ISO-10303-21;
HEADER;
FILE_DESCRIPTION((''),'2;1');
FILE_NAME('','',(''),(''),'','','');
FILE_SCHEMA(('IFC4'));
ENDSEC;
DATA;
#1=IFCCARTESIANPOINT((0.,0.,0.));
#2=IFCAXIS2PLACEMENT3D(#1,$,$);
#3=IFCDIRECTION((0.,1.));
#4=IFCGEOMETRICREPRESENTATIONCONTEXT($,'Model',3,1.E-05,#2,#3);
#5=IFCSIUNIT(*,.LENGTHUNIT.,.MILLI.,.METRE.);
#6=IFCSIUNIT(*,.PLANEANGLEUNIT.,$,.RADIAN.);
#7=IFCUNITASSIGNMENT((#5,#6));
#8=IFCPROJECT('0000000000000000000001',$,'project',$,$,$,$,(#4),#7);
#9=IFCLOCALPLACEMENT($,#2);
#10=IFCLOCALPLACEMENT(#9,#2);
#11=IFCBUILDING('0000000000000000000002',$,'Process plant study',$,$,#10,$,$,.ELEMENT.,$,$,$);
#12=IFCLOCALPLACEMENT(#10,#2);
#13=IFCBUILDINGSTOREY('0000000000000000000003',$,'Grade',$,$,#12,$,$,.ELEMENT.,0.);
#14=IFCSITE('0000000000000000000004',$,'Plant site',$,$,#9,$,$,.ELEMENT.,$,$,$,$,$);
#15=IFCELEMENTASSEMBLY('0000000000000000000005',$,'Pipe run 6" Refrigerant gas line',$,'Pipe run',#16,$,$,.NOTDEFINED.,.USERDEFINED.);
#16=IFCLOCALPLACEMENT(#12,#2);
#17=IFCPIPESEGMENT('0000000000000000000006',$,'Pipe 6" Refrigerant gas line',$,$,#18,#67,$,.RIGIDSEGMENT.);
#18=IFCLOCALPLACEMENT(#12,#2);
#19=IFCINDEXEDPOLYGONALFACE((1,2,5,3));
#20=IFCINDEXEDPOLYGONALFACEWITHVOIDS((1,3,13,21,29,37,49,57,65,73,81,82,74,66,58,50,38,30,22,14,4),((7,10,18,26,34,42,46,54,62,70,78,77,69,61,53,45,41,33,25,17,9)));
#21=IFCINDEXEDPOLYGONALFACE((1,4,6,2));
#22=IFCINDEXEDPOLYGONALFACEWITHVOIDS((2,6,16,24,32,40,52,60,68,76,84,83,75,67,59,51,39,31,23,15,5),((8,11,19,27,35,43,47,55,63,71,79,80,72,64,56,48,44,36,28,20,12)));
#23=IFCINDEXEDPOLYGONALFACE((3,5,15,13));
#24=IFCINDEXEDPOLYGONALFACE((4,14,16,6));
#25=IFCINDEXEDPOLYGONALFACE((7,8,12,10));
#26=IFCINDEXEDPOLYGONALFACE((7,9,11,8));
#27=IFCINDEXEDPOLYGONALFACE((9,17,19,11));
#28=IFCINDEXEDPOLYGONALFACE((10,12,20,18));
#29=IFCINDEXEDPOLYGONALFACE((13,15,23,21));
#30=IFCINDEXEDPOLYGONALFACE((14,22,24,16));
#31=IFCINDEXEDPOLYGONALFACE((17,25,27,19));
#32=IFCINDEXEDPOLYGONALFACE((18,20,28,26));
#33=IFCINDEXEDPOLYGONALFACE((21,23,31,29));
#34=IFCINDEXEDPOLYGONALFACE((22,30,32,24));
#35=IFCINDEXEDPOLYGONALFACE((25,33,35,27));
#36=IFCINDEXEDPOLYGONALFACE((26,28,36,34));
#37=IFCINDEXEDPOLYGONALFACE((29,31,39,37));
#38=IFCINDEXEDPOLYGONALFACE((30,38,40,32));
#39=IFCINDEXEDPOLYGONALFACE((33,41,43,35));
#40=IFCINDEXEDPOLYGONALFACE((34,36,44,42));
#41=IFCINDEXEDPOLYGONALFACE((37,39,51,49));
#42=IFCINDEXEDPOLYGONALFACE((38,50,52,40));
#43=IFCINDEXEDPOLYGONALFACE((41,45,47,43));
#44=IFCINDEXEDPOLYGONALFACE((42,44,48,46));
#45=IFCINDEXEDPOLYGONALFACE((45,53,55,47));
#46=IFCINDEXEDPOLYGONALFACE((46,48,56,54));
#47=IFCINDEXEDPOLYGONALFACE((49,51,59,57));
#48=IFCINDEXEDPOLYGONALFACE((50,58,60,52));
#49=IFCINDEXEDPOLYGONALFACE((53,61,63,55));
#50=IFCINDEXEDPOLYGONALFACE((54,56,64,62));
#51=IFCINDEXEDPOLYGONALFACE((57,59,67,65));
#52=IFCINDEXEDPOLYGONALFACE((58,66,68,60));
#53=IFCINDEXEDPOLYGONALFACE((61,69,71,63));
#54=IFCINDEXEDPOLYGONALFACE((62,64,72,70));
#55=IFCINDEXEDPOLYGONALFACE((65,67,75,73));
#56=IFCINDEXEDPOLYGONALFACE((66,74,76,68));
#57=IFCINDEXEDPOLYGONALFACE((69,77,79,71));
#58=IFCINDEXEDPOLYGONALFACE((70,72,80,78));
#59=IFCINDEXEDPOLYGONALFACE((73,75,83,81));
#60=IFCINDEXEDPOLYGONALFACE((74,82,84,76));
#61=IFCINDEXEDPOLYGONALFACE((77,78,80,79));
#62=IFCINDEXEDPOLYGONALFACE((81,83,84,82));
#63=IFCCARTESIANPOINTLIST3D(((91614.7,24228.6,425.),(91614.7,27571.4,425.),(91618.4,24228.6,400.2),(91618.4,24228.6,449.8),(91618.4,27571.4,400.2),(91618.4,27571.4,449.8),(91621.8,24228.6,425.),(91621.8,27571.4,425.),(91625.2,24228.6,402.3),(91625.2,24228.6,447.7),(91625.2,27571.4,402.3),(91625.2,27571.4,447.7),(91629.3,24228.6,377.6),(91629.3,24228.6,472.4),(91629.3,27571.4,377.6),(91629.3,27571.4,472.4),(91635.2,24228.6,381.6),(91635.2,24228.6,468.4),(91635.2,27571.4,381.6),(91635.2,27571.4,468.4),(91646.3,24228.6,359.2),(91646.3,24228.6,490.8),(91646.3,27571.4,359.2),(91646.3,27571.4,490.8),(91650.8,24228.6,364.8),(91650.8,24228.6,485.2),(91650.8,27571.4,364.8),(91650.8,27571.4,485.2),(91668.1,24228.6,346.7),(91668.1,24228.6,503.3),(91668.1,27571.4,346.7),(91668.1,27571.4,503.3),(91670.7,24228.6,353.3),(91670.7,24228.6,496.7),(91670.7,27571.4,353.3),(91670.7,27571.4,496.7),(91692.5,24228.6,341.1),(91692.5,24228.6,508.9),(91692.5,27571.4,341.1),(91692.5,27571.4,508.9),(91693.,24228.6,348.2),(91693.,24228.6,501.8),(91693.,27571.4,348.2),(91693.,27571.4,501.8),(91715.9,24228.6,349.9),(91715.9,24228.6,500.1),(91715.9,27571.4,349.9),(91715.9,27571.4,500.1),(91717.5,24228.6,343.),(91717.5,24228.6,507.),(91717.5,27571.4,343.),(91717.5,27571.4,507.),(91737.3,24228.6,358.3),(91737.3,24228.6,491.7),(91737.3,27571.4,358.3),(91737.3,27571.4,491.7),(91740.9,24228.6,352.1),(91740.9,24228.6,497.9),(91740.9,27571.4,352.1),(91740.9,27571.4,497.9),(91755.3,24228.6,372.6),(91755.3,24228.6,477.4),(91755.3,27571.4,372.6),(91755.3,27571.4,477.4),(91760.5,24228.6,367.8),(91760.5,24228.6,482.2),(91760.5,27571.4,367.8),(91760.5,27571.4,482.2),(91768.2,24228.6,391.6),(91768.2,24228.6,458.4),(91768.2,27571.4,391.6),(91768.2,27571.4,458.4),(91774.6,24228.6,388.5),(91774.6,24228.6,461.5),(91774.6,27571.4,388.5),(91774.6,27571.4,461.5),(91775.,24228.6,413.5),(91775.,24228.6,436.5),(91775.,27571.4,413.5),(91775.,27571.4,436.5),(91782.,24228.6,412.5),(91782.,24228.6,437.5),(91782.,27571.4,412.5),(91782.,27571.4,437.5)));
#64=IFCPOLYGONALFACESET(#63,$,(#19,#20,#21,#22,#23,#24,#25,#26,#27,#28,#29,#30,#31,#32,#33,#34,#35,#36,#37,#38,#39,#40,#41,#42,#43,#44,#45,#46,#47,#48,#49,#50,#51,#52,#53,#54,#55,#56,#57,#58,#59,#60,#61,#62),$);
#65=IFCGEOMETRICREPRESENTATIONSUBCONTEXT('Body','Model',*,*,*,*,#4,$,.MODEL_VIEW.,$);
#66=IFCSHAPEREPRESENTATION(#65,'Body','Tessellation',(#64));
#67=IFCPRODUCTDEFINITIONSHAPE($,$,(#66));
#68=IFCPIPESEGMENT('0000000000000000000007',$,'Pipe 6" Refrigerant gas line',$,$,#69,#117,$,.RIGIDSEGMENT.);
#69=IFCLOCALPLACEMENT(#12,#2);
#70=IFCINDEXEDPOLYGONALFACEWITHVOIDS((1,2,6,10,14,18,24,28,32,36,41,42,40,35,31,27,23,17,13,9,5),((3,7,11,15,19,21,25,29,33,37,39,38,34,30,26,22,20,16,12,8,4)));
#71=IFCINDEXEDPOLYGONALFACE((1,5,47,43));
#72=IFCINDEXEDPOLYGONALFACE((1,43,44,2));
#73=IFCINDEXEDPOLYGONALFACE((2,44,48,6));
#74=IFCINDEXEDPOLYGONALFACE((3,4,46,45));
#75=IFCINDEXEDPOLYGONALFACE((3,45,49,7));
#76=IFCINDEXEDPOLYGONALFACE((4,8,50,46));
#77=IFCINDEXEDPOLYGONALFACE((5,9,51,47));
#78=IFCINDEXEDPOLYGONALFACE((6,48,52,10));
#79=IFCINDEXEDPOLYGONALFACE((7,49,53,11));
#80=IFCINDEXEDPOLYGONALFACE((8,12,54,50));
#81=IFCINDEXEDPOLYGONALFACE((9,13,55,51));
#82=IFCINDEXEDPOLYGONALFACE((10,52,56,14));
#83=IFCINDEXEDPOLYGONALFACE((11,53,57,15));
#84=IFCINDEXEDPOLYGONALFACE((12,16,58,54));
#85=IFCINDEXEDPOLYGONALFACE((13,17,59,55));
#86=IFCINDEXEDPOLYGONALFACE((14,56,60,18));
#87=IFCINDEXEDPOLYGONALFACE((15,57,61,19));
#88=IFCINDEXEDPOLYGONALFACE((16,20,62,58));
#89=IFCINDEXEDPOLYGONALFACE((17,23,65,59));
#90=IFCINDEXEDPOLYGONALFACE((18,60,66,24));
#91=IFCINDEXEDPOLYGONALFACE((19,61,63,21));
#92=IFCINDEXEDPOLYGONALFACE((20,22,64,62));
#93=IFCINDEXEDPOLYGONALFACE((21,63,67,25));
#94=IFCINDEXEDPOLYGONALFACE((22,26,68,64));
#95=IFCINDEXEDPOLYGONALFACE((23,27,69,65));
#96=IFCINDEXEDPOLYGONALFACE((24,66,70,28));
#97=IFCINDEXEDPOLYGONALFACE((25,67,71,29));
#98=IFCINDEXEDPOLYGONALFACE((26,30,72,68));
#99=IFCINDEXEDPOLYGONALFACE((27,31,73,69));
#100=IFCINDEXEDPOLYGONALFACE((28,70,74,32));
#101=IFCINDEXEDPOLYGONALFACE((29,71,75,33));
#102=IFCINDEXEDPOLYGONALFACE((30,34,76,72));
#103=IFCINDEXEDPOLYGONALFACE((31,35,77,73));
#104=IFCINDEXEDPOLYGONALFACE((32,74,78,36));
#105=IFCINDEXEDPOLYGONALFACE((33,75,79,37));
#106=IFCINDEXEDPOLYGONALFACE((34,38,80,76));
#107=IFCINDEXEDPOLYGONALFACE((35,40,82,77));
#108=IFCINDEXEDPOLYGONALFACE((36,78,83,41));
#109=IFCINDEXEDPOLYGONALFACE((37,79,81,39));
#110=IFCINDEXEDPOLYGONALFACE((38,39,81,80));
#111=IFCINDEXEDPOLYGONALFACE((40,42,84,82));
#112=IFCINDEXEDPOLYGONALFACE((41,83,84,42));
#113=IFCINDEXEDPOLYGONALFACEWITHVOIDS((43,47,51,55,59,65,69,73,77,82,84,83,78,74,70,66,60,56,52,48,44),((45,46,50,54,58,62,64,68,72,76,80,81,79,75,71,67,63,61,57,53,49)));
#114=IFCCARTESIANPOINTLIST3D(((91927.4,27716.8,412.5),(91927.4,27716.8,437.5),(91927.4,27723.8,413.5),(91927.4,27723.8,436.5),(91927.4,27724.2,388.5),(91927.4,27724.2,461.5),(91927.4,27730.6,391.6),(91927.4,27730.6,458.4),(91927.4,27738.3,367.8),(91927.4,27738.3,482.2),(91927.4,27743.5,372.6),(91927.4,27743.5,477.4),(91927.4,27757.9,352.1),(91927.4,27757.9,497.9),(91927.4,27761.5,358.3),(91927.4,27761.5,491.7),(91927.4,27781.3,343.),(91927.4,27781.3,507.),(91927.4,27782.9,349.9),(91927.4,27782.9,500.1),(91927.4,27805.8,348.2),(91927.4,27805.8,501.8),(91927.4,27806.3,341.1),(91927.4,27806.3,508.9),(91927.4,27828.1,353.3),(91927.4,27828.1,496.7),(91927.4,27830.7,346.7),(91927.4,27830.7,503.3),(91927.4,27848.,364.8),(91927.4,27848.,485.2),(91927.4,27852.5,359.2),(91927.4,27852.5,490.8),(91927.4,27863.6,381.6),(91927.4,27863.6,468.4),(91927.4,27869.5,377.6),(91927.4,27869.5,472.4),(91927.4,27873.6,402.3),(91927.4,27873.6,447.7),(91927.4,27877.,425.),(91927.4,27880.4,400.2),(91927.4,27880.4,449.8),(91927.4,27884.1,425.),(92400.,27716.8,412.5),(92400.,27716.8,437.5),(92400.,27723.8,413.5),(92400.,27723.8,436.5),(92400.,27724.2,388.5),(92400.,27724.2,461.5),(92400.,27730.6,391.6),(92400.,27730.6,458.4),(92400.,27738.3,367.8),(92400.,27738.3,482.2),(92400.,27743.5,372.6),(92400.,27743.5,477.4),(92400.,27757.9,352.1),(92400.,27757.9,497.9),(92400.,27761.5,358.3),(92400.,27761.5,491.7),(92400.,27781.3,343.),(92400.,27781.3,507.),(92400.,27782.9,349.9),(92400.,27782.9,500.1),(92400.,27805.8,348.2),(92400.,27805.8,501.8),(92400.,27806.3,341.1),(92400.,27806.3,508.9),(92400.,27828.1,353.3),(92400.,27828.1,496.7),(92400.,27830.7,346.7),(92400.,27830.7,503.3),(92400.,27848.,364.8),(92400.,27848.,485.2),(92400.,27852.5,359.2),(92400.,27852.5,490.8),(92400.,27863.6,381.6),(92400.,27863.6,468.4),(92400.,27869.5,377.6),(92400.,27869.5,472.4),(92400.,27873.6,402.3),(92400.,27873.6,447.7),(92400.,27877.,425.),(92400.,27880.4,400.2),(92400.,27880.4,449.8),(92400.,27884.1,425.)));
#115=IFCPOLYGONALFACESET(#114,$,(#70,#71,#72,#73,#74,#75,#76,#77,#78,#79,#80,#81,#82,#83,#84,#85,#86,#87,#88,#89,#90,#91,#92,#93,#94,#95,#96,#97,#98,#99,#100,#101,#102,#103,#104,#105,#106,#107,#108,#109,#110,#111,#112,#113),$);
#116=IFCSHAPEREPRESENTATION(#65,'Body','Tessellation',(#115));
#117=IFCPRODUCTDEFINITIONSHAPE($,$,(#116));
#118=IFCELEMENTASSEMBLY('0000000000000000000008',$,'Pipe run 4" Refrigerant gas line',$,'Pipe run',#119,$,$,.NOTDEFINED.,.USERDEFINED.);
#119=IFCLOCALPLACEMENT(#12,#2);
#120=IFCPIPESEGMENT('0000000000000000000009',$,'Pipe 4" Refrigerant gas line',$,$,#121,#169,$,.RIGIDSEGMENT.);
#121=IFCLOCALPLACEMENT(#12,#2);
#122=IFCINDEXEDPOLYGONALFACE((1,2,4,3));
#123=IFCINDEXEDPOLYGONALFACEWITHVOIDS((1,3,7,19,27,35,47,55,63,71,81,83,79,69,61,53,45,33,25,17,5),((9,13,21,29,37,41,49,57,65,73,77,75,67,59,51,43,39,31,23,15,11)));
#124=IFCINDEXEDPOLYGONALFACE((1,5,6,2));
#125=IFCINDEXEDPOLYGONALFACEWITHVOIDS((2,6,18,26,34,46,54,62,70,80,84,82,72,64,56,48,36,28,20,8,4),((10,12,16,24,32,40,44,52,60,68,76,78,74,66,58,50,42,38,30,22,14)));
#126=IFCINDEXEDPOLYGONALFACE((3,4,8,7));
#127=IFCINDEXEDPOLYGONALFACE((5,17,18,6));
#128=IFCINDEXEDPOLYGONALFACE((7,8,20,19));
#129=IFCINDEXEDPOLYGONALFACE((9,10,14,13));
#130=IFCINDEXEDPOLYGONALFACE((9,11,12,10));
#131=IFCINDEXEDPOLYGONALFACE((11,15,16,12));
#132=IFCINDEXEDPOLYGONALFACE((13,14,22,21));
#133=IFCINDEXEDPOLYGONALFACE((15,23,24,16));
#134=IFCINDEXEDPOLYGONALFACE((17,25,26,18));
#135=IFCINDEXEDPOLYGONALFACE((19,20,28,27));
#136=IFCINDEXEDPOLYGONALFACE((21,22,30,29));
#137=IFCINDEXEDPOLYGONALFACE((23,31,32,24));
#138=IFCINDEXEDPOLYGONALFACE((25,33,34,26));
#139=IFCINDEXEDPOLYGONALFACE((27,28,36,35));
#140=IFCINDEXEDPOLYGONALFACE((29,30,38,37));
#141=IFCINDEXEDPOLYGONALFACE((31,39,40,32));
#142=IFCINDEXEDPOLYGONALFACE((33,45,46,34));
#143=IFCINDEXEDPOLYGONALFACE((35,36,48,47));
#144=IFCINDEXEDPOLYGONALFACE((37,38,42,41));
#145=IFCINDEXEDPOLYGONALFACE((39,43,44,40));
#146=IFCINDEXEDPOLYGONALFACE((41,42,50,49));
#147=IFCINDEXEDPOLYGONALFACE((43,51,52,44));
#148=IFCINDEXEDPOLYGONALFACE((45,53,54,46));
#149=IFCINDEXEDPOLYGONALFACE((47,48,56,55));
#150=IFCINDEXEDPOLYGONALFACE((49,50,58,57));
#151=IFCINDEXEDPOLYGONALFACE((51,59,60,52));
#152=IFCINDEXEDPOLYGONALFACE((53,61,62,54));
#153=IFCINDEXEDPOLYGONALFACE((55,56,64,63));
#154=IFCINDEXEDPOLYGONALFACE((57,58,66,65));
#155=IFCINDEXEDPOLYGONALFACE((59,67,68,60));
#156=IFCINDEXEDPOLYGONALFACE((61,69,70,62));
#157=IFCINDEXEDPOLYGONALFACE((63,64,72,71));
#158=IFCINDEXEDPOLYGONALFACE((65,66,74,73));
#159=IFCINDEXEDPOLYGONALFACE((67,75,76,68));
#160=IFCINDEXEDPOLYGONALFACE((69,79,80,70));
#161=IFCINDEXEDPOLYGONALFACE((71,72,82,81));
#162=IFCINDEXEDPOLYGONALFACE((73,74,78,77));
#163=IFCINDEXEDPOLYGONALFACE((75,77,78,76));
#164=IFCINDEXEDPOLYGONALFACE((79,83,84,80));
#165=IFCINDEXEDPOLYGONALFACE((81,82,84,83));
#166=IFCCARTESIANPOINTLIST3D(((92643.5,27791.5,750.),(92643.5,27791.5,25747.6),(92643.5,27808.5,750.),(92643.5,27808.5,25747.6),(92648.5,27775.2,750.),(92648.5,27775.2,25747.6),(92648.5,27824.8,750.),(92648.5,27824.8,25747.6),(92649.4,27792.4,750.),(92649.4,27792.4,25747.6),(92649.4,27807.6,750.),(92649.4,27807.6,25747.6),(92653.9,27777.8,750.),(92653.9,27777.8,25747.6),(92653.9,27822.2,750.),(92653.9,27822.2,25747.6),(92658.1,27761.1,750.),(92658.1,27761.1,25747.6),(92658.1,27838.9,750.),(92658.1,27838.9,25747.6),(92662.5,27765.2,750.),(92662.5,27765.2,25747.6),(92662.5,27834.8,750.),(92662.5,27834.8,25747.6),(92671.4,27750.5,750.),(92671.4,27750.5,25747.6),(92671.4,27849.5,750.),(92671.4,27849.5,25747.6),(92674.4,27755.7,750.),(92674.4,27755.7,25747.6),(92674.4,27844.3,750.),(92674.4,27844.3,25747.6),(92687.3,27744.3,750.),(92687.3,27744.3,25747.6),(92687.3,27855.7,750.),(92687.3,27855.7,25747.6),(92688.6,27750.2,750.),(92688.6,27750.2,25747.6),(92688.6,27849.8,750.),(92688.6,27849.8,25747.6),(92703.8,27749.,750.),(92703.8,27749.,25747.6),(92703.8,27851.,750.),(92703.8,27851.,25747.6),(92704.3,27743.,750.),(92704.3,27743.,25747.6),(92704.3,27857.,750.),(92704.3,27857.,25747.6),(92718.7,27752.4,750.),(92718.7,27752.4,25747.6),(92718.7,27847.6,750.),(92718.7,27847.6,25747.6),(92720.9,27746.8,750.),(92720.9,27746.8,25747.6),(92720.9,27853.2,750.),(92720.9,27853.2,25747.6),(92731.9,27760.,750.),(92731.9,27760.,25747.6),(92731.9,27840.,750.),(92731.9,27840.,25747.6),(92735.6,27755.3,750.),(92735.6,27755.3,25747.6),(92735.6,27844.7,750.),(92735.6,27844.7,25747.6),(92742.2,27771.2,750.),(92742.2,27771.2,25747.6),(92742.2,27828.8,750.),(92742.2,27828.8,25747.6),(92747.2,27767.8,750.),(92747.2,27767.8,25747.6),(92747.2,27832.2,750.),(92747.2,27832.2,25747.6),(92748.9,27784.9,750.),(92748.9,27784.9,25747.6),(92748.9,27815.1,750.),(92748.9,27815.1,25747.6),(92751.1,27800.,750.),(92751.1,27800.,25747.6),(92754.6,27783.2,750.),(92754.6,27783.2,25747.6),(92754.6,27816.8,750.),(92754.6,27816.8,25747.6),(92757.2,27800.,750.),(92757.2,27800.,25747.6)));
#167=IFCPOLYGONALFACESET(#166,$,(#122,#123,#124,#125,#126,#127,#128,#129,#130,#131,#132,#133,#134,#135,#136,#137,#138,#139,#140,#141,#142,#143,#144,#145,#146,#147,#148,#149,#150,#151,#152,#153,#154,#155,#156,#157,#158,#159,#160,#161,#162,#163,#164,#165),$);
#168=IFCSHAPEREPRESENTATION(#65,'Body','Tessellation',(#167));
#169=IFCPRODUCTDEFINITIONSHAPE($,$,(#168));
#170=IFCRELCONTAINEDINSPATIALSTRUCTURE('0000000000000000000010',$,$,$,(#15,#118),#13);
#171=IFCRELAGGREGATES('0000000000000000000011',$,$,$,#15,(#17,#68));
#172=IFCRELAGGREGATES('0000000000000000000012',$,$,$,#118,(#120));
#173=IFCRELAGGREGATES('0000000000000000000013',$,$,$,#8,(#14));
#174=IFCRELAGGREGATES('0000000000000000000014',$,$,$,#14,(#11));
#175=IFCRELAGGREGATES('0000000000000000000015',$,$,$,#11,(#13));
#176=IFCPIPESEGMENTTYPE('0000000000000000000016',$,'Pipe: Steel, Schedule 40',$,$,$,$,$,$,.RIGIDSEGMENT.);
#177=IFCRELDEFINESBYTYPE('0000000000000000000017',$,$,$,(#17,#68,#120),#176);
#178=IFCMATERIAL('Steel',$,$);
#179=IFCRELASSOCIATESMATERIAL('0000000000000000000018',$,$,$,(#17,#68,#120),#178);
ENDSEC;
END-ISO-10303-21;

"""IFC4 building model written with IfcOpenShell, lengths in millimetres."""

from ifc_helpers import new_model, si_unit, direction, frame, origin, origin_with_axes, origin_2d, place, context, subcontext, project, spatial, hollow_circle, extrude, material, type_object, element, aggregate, save


model = new_model("IFC4")

# Units and contexts
model_context = context("Model", 3, precision=1e-05, world=origin(), true_north=direction((0.0, 1.0)))
body_context = subcontext(model_context, "Body", "Model", "MODEL_VIEW")
ifc_project = project(units=[si_unit("LENGTHUNIT", "METRE", prefix="MILLI"), si_unit("PLANEANGLEUNIT", "RADIAN")], contexts=[model_context])

# Site, building, storey
site_placement = place(None, origin())
site = spatial("IfcSite", under=ifc_project, at=site_placement, Name="Plant site", CompositionType="ELEMENT")
building_placement = place(site_placement, origin())
building = spatial("IfcBuilding", under=site, at=building_placement, Name="Process plant study", CompositionType="ELEMENT")
storey_placement = place(building_placement, origin())
storey = spatial("IfcBuildingStorey", under=building, at=storey_placement, Name="Grade", CompositionType="ELEMENT", Elevation=0.0)

# Element assemblies, pipe segments
ifc_material = material(Name="Steel")
pipe_segment_type = type_object("IfcPipeSegmentType", Name="Pipe: Steel, Schedule 40", PredefinedType="RIGIDSEGMENT")
assembly_1_placement = place(storey_placement, origin_with_axes())
assembly_1 = element("IfcElementAssembly", 1, at=assembly_1_placement, inside=storey, Name="Pipe run 6\" Refrigerant gas line", ObjectType="Pipe run", AssemblyPlace="NOTDEFINED", PredefinedType="USERDEFINED")
pipe_segment_1_placement = place(storey_placement, origin_with_axes())
pipe_segment_1 = element("IfcPipeSegment", 2, at=pipe_segment_1_placement, type_object=pipe_segment_type, material=ifc_material, Name="Pipe 6\" Refrigerant gas line", PredefinedType="RIGIDSEGMENT", context=body_context, shape_type="SweptSolid", body=[
    extrude(hollow_circle(Radius=84.1, WallThickness=7.1, at=origin_2d()), frame((91698.8, 24228.6, 425.0), z_axis=(0.0, 1.0, 0.0), x_axis=(-1.0, 0.0, 0.0)), (0.0, 0.0, 1.0), 3342.8),
])
pipe_segment_2_placement = place(storey_placement, origin_with_axes())
pipe_segment_2 = element("IfcPipeSegment", 3, at=pipe_segment_2_placement, type_object=pipe_segment_type, material=ifc_material, Name="Pipe 6\" Refrigerant gas line", PredefinedType="RIGIDSEGMENT", context=body_context, shape_type="SweptSolid", body=[
    extrude(hollow_circle(Radius=84.1, WallThickness=7.1, at=origin_2d()), frame((91927.4, 27800.0, 425.0), z_axis=(1.0, 0.0, 0.0), x_axis=(0.0, 1.0, 0.0)), (0.0, 0.0, 1.0), 472.6),
])
assembly_2_placement = place(storey_placement, origin_with_axes())
assembly_2 = element("IfcElementAssembly", 4, at=assembly_2_placement, inside=storey, Name="Pipe run 4\" Refrigerant gas line", ObjectType="Pipe run", AssemblyPlace="NOTDEFINED", PredefinedType="USERDEFINED")
pipe_segment_3_placement = place(storey_placement, origin_with_axes())
pipe_segment_3 = element("IfcPipeSegment", 5, at=pipe_segment_3_placement, type_object=pipe_segment_type, material=ifc_material, Name="Pipe 4\" Refrigerant gas line", PredefinedType="RIGIDSEGMENT", context=body_context, shape_type="SweptSolid", body=[
    extrude(hollow_circle(Radius=57.1, WallThickness=6.0, at=origin_2d()), frame((92700.0, 27800.0, 750.0), z_axis=(0.0, 0.0, 1.0), x_axis=(1.0, 0.0, 0.0)), (0.0, 0.0, 1.0), 24997.6),
])

aggregate(assembly_1, [pipe_segment_1, pipe_segment_2])
aggregate(assembly_2, [pipe_segment_3])

save(model, "model.ifc")
